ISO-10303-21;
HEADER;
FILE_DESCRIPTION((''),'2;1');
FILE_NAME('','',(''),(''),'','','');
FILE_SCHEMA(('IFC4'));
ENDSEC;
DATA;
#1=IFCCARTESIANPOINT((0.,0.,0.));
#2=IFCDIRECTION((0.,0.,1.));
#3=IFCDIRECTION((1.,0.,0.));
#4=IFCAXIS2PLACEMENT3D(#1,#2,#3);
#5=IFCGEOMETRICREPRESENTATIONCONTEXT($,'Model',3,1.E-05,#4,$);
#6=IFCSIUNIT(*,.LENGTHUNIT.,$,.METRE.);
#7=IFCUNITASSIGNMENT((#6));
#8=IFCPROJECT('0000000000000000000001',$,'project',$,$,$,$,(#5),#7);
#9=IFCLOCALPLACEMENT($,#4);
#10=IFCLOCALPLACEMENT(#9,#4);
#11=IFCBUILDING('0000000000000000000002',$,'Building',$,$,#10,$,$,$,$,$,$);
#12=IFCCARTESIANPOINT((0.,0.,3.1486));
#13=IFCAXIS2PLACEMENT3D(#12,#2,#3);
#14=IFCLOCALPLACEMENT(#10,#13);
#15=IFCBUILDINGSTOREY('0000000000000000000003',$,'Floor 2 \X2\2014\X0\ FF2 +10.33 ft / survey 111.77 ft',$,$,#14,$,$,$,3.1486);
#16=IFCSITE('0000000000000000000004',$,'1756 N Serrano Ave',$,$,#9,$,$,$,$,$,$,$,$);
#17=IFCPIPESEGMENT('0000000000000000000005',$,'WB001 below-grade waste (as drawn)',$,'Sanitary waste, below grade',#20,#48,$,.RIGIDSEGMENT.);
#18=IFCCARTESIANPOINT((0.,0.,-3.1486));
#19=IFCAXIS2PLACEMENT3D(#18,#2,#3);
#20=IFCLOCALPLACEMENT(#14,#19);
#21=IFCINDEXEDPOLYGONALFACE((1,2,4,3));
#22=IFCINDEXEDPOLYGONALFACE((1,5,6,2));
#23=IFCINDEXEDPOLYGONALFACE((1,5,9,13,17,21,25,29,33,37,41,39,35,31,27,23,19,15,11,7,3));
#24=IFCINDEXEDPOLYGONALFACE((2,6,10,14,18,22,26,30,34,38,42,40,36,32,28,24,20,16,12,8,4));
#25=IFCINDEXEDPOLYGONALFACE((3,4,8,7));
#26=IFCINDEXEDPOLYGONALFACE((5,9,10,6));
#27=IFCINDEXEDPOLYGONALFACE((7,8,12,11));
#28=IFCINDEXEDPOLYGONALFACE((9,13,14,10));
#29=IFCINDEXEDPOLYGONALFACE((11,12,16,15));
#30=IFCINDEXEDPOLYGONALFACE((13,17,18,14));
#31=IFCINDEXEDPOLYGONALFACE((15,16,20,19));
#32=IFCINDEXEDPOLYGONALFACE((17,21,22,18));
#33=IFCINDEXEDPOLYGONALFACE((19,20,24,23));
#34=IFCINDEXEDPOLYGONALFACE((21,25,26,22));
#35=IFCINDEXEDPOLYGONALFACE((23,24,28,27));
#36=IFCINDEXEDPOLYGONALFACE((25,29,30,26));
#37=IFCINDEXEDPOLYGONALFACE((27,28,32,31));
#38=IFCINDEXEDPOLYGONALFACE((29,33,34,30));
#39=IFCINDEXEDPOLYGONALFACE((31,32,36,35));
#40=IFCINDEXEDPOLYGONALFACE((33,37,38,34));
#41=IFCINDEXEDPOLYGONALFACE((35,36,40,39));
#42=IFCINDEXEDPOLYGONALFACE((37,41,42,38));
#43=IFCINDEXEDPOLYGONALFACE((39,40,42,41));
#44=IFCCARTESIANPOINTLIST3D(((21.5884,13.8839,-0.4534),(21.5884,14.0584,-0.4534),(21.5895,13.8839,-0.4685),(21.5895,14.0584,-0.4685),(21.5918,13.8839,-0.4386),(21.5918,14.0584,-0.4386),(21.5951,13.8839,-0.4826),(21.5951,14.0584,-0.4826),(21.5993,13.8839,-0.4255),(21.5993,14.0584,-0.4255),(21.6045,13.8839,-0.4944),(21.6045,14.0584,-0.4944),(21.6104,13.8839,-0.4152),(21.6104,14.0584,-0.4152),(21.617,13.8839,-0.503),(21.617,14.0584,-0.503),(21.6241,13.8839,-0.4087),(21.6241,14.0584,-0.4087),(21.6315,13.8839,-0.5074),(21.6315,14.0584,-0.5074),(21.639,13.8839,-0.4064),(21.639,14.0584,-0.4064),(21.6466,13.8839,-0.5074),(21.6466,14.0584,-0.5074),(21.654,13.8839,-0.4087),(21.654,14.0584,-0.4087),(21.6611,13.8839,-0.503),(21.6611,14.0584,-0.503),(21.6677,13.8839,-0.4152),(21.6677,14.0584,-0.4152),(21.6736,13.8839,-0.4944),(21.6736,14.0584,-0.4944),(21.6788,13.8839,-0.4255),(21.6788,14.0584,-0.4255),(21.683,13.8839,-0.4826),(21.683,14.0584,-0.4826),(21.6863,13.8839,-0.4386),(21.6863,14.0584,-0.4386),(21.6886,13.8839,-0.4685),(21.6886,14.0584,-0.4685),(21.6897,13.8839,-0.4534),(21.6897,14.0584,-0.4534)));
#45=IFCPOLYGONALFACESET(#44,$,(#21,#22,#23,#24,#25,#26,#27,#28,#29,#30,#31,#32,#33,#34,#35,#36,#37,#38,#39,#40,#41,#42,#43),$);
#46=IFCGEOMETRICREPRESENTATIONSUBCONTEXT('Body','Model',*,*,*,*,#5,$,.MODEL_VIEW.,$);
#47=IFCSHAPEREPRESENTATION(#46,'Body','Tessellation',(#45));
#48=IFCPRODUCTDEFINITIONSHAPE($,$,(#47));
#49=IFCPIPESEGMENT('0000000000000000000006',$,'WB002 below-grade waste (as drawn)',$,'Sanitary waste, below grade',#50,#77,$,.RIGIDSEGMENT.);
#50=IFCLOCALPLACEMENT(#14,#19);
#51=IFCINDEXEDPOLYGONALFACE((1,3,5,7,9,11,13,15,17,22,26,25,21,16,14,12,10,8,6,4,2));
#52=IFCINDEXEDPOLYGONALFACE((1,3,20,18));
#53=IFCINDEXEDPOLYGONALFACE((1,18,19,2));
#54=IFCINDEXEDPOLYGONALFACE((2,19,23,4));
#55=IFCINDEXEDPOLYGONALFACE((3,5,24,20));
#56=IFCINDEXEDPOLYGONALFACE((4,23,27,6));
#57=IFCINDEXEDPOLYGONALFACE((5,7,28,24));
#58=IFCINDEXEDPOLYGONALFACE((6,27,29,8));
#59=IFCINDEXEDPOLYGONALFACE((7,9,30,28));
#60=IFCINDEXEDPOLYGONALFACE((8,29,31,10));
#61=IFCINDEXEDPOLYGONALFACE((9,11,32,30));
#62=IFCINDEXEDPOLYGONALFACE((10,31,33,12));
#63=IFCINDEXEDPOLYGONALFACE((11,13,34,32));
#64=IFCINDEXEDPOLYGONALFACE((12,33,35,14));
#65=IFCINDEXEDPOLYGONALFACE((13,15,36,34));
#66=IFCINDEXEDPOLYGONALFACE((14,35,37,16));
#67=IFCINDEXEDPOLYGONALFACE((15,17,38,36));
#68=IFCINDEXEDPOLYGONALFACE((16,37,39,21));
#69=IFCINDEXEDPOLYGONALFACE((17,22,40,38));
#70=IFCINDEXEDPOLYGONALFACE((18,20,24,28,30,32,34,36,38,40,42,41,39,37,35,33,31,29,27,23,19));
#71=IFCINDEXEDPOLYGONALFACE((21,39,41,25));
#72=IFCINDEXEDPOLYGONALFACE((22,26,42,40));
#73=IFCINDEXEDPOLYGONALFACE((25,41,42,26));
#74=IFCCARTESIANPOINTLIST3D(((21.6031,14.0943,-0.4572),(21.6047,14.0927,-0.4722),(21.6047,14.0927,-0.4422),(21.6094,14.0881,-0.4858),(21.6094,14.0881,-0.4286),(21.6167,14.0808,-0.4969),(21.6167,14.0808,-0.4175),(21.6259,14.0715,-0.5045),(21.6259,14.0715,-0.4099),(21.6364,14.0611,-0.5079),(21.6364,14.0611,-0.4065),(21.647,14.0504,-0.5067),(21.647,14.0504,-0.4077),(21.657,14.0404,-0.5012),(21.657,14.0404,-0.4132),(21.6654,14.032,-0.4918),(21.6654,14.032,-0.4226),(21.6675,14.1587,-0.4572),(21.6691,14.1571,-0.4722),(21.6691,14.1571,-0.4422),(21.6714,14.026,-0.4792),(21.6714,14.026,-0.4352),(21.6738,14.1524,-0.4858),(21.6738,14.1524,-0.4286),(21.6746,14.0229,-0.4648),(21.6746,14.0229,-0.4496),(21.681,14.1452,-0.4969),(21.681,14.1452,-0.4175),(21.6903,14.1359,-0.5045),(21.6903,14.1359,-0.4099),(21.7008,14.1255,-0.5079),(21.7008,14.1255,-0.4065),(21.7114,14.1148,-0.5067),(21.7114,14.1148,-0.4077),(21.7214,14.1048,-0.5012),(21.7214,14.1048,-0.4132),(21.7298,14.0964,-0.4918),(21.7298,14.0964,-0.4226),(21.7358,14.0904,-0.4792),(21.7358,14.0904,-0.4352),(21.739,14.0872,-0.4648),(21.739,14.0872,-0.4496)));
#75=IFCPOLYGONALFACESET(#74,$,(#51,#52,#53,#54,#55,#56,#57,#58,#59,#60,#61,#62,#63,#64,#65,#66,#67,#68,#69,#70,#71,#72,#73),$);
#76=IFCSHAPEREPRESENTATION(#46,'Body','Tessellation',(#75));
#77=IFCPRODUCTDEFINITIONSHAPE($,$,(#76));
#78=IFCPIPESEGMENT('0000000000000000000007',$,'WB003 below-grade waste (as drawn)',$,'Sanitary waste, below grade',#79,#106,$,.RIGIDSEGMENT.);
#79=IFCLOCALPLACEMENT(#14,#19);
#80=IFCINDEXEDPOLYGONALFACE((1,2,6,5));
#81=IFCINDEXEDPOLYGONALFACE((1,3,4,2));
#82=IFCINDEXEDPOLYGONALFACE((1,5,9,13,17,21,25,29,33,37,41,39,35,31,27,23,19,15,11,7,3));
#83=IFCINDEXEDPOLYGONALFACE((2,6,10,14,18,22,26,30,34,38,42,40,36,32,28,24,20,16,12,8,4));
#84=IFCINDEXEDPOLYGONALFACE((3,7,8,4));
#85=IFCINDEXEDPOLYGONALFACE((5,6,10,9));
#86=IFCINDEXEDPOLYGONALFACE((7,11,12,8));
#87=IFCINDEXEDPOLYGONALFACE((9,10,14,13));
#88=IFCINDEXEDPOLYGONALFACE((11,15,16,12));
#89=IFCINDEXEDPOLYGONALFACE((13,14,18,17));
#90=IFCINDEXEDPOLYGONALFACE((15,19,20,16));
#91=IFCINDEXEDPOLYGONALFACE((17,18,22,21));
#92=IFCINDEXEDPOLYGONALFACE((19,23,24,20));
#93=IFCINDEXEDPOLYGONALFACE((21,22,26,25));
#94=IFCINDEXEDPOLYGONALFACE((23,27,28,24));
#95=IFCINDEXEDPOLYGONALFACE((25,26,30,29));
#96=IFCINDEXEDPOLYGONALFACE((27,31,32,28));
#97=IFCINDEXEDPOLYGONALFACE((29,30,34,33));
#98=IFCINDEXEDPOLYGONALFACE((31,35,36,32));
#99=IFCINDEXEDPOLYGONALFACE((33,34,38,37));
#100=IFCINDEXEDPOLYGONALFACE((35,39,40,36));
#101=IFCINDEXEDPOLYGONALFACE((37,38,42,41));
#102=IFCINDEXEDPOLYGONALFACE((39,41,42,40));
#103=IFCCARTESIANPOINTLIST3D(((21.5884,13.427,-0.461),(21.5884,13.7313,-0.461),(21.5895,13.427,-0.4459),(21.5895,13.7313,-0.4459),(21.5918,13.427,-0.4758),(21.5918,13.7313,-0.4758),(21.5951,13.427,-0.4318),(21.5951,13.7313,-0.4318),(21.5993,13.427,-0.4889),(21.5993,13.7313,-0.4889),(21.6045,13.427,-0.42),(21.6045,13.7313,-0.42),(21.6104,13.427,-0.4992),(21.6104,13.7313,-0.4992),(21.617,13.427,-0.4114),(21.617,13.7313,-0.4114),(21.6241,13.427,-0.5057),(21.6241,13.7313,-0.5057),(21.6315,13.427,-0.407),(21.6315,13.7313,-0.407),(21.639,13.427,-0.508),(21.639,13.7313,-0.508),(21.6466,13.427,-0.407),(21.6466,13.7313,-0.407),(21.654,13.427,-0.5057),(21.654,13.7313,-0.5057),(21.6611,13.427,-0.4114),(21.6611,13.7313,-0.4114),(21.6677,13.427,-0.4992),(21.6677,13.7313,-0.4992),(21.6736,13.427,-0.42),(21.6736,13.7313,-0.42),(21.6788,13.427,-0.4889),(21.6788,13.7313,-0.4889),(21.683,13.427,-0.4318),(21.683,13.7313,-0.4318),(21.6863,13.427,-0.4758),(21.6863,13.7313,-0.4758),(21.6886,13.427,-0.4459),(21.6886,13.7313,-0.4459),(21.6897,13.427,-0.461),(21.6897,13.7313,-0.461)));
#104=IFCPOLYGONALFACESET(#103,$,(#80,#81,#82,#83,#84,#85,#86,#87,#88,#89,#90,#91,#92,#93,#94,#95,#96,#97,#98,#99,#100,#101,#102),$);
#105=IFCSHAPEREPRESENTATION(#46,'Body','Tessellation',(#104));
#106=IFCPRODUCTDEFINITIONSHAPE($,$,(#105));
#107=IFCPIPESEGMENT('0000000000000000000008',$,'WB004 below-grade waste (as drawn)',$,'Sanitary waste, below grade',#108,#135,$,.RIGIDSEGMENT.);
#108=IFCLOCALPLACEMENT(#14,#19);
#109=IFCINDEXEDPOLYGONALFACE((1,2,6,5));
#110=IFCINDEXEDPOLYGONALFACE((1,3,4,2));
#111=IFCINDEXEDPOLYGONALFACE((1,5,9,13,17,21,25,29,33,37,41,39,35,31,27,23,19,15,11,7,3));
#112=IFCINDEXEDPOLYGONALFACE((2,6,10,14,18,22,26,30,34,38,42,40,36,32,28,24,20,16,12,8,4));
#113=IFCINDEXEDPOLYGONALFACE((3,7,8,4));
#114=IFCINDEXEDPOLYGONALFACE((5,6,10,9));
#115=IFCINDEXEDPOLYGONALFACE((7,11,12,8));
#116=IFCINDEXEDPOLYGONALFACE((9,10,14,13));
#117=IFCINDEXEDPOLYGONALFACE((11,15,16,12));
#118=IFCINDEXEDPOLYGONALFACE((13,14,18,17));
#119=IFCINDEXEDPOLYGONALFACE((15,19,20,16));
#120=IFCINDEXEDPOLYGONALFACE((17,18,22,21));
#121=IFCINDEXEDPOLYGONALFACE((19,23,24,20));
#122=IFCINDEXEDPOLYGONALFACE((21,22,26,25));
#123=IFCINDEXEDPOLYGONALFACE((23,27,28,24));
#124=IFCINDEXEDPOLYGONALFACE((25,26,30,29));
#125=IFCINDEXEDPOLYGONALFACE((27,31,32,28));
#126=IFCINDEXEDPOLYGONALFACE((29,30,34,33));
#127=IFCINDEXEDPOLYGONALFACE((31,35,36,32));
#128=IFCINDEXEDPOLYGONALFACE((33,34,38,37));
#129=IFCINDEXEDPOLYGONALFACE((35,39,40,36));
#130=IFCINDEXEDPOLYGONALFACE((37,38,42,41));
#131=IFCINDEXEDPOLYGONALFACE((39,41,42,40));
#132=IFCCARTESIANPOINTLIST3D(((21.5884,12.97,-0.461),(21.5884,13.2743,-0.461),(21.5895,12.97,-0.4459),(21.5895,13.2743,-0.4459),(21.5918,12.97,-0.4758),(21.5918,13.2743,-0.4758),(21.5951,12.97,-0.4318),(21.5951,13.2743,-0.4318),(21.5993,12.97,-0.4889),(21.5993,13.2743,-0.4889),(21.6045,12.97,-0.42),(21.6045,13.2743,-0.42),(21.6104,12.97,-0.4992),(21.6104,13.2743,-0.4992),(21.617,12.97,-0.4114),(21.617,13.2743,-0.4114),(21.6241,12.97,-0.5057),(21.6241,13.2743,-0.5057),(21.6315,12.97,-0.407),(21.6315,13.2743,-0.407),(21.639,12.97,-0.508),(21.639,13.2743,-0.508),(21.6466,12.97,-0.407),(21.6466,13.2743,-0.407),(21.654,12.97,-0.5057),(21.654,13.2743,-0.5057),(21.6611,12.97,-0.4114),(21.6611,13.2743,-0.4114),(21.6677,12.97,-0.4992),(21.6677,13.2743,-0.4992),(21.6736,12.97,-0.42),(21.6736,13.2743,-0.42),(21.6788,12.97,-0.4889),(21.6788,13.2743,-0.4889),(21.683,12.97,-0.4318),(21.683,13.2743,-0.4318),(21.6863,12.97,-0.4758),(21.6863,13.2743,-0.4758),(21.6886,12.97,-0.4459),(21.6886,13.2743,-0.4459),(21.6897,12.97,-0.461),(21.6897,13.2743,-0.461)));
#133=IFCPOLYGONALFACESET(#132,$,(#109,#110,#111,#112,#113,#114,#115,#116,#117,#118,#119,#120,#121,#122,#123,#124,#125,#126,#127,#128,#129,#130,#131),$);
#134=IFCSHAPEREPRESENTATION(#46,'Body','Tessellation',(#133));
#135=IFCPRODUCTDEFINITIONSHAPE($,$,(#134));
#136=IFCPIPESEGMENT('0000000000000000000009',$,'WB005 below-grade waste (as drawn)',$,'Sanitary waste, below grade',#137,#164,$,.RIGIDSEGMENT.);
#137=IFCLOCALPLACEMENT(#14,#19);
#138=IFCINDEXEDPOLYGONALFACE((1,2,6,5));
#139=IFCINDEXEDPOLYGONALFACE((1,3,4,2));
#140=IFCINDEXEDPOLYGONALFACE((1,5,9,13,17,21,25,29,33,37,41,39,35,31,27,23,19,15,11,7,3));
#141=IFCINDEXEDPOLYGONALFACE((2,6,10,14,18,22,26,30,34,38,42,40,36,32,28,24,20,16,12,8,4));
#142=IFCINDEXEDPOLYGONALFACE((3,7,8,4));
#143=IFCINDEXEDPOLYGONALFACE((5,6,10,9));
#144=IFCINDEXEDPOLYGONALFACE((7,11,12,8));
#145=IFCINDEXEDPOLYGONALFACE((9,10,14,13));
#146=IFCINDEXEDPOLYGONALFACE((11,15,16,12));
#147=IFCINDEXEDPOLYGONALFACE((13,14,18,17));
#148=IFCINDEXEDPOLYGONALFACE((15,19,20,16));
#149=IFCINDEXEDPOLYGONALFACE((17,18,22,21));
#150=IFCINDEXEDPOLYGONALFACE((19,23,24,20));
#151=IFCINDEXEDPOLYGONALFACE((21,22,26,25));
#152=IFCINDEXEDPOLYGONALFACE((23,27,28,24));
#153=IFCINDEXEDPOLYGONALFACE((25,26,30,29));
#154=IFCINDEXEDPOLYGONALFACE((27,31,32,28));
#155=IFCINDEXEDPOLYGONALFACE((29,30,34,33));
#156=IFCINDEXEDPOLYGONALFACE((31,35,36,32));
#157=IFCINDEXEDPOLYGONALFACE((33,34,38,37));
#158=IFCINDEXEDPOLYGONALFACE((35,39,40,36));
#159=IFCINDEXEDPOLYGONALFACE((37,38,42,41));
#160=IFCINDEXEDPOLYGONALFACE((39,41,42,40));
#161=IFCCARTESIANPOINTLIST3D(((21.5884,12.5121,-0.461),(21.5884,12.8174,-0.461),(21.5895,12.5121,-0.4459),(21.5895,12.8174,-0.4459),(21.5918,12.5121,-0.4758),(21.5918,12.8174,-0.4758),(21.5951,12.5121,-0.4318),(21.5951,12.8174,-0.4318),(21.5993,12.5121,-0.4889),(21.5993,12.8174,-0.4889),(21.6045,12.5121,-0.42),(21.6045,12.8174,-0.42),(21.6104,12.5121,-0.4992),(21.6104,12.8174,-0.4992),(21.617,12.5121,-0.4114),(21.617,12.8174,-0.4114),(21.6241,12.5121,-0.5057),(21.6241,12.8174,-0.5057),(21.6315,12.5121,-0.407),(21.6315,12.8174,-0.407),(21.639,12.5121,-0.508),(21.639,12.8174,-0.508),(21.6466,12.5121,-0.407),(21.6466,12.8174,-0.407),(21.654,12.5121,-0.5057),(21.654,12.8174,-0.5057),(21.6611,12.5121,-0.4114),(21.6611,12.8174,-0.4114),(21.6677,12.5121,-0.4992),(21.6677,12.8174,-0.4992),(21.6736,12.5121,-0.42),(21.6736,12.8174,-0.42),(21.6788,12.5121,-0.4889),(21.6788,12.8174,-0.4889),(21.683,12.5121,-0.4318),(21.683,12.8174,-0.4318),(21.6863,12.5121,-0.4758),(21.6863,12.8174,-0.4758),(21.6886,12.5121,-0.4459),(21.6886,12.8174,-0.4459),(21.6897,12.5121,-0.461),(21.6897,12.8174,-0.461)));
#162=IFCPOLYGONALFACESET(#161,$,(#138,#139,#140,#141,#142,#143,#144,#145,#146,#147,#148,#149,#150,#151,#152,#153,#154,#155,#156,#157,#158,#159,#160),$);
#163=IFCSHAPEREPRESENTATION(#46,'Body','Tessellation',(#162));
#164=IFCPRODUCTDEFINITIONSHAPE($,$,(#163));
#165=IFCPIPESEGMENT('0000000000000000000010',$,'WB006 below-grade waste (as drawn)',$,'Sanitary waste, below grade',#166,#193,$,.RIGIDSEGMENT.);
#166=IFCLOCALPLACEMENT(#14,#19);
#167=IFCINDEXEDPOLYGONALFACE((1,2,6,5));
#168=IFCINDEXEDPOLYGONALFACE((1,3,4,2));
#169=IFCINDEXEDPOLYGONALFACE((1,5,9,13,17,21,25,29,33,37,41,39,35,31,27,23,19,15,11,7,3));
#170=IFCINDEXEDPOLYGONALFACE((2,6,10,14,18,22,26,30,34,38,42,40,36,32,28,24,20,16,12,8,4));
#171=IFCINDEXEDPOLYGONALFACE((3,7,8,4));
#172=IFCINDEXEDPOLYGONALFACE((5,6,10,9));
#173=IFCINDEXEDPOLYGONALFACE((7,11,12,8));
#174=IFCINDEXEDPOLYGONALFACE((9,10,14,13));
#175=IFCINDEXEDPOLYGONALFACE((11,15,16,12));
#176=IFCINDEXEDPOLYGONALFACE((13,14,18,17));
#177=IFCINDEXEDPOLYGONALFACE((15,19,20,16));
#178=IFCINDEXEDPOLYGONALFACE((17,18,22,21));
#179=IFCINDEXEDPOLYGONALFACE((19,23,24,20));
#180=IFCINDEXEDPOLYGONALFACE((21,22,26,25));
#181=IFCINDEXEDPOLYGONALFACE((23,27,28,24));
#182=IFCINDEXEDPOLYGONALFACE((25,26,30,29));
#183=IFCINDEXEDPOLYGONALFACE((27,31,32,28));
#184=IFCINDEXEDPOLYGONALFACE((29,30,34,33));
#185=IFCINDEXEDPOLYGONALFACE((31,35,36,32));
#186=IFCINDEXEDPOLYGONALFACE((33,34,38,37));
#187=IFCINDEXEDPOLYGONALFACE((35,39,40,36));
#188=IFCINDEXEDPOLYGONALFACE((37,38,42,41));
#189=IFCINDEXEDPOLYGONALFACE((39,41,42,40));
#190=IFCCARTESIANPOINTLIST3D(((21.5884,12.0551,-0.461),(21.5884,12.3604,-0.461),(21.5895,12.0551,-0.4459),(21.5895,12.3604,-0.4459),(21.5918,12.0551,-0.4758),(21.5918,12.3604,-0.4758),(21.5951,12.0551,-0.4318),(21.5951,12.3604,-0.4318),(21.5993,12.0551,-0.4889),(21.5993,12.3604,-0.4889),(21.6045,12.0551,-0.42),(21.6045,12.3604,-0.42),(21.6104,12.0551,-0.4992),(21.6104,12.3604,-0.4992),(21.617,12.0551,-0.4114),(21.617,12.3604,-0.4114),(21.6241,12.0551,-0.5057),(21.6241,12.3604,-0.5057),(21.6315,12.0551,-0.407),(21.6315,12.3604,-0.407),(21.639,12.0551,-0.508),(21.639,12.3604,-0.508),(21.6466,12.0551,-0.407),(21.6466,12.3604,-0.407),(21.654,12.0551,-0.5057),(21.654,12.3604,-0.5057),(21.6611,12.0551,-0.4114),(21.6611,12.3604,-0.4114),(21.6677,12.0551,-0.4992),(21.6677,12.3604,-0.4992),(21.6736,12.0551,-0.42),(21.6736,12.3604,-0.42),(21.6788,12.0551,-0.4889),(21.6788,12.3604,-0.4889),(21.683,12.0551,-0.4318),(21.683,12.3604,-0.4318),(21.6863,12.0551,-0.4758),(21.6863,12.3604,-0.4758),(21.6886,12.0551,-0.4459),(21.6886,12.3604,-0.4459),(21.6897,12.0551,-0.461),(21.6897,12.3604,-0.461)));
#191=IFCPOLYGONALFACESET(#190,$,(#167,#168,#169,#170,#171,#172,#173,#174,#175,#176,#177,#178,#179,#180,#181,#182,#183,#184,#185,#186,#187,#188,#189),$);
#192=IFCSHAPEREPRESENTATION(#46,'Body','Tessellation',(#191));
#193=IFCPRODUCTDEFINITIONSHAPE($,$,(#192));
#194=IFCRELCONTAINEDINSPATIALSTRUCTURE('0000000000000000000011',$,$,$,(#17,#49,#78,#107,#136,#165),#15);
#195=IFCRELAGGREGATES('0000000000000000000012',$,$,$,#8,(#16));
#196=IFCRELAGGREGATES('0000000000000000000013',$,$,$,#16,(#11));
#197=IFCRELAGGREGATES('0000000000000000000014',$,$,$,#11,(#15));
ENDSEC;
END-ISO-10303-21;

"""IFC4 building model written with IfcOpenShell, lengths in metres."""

from ifc_helpers import new_model, entity, si_unit, frame, origin_with_axes, place, context, subcontext, project, spatial, element, save


model = new_model("IFC4")

# Units and contexts
model_context = context("Model", 3, precision=1e-05, world=origin_with_axes())
body_context = subcontext(model_context, "Body", "Model", "MODEL_VIEW")
ifc_project = project(units=[si_unit("LENGTHUNIT", "METRE")], contexts=[model_context])

# Site, building, storey
site_placement = place(None, origin_with_axes())
site = spatial("IfcSite", under=ifc_project, at=site_placement, Name="1756 N Serrano Ave")
building_placement = place(site_placement, origin_with_axes())
building = spatial("IfcBuilding", under=site, at=building_placement, Name="Building")
storey_placement = place(building_placement, frame((0.0, 0.0, 3.1486), z_axis=(0.0, 0.0, 1.0), x_axis=(1.0, 0.0, 0.0)))
storey = spatial("IfcBuildingStorey", under=building, at=storey_placement, Name="Floor 2 — FF2 +10.33 ft / survey 111.77 ft", Elevation=3.1486)

# Pipe segments
pipe_segment_1_placement = place(storey_placement, frame((0.0, 0.0, -3.1486), z_axis=(0.0, 0.0, 1.0), x_axis=(1.0, 0.0, 0.0)))
element("IfcPipeSegment", 1, at=pipe_segment_1_placement, inside=storey, Name="WB001 below-grade waste (as drawn)", ObjectType="Sanitary waste, below grade", PredefinedType="RIGIDSEGMENT", context=body_context, shape_type="AdvancedSweptSolid", body=[
    entity("IfcSweptDiskSolid", entity("IfcPolyline", [entity("IfcCartesianPoint", [21.639, 13.8839, -0.4572]), entity("IfcCartesianPoint", [21.639, 14.0584, -0.4572])]), 0.0508),
])
pipe_segment_2_placement = place(storey_placement, frame((0.0, 0.0, -3.1486), z_axis=(0.0, 0.0, 1.0), x_axis=(1.0, 0.0, 0.0)))
element("IfcPipeSegment", 2, at=pipe_segment_2_placement, inside=storey, Name="WB002 below-grade waste (as drawn)", ObjectType="Sanitary waste, below grade", PredefinedType="RIGIDSEGMENT", context=body_context, shape_type="AdvancedSweptSolid", body=[
    entity("IfcSweptDiskSolid", entity("IfcPolyline", [entity("IfcCartesianPoint", [21.639, 14.0584, -0.4572]), entity("IfcCartesianPoint", [21.7034, 14.1228, -0.4572])]), 0.0508),
])
pipe_segment_3_placement = place(storey_placement, frame((0.0, 0.0, -3.1486), z_axis=(0.0, 0.0, 1.0), x_axis=(1.0, 0.0, 0.0)))
element("IfcPipeSegment", 3, at=pipe_segment_3_placement, inside=storey, Name="WB003 below-grade waste (as drawn)", ObjectType="Sanitary waste, below grade", PredefinedType="RIGIDSEGMENT", context=body_context, shape_type="AdvancedSweptSolid", body=[
    entity("IfcSweptDiskSolid", entity("IfcPolyline", [entity("IfcCartesianPoint", [21.639, 13.7313, -0.4572]), entity("IfcCartesianPoint", [21.639, 13.427, -0.4572])]), 0.0508),
])
pipe_segment_4_placement = place(storey_placement, frame((0.0, 0.0, -3.1486), z_axis=(0.0, 0.0, 1.0), x_axis=(1.0, 0.0, 0.0)))
element("IfcPipeSegment", 4, at=pipe_segment_4_placement, inside=storey, Name="WB004 below-grade waste (as drawn)", ObjectType="Sanitary waste, below grade", PredefinedType="RIGIDSEGMENT", context=body_context, shape_type="AdvancedSweptSolid", body=[
    entity("IfcSweptDiskSolid", entity("IfcPolyline", [entity("IfcCartesianPoint", [21.639, 13.2743, -0.4572]), entity("IfcCartesianPoint", [21.639, 12.97, -0.4572])]), 0.0508),
])
pipe_segment_5_placement = place(storey_placement, frame((0.0, 0.0, -3.1486), z_axis=(0.0, 0.0, 1.0), x_axis=(1.0, 0.0, 0.0)))
element("IfcPipeSegment", 5, at=pipe_segment_5_placement, inside=storey, Name="WB005 below-grade waste (as drawn)", ObjectType="Sanitary waste, below grade", PredefinedType="RIGIDSEGMENT", context=body_context, shape_type="AdvancedSweptSolid", body=[
    entity("IfcSweptDiskSolid", entity("IfcPolyline", [entity("IfcCartesianPoint", [21.639, 12.8174, -0.4572]), entity("IfcCartesianPoint", [21.639, 12.5121, -0.4572])]), 0.0508),
])
pipe_segment_6_placement = place(storey_placement, frame((0.0, 0.0, -3.1486), z_axis=(0.0, 0.0, 1.0), x_axis=(1.0, 0.0, 0.0)))
element("IfcPipeSegment", 6, at=pipe_segment_6_placement, inside=storey, Name="WB006 below-grade waste (as drawn)", ObjectType="Sanitary waste, below grade", PredefinedType="RIGIDSEGMENT", context=body_context, shape_type="AdvancedSweptSolid", body=[
    entity("IfcSweptDiskSolid", entity("IfcPolyline", [entity("IfcCartesianPoint", [21.639, 12.3604, -0.4572]), entity("IfcCartesianPoint", [21.639, 12.0551, -0.4572])]), 0.0508),
])

save(model, "model.ifc")
